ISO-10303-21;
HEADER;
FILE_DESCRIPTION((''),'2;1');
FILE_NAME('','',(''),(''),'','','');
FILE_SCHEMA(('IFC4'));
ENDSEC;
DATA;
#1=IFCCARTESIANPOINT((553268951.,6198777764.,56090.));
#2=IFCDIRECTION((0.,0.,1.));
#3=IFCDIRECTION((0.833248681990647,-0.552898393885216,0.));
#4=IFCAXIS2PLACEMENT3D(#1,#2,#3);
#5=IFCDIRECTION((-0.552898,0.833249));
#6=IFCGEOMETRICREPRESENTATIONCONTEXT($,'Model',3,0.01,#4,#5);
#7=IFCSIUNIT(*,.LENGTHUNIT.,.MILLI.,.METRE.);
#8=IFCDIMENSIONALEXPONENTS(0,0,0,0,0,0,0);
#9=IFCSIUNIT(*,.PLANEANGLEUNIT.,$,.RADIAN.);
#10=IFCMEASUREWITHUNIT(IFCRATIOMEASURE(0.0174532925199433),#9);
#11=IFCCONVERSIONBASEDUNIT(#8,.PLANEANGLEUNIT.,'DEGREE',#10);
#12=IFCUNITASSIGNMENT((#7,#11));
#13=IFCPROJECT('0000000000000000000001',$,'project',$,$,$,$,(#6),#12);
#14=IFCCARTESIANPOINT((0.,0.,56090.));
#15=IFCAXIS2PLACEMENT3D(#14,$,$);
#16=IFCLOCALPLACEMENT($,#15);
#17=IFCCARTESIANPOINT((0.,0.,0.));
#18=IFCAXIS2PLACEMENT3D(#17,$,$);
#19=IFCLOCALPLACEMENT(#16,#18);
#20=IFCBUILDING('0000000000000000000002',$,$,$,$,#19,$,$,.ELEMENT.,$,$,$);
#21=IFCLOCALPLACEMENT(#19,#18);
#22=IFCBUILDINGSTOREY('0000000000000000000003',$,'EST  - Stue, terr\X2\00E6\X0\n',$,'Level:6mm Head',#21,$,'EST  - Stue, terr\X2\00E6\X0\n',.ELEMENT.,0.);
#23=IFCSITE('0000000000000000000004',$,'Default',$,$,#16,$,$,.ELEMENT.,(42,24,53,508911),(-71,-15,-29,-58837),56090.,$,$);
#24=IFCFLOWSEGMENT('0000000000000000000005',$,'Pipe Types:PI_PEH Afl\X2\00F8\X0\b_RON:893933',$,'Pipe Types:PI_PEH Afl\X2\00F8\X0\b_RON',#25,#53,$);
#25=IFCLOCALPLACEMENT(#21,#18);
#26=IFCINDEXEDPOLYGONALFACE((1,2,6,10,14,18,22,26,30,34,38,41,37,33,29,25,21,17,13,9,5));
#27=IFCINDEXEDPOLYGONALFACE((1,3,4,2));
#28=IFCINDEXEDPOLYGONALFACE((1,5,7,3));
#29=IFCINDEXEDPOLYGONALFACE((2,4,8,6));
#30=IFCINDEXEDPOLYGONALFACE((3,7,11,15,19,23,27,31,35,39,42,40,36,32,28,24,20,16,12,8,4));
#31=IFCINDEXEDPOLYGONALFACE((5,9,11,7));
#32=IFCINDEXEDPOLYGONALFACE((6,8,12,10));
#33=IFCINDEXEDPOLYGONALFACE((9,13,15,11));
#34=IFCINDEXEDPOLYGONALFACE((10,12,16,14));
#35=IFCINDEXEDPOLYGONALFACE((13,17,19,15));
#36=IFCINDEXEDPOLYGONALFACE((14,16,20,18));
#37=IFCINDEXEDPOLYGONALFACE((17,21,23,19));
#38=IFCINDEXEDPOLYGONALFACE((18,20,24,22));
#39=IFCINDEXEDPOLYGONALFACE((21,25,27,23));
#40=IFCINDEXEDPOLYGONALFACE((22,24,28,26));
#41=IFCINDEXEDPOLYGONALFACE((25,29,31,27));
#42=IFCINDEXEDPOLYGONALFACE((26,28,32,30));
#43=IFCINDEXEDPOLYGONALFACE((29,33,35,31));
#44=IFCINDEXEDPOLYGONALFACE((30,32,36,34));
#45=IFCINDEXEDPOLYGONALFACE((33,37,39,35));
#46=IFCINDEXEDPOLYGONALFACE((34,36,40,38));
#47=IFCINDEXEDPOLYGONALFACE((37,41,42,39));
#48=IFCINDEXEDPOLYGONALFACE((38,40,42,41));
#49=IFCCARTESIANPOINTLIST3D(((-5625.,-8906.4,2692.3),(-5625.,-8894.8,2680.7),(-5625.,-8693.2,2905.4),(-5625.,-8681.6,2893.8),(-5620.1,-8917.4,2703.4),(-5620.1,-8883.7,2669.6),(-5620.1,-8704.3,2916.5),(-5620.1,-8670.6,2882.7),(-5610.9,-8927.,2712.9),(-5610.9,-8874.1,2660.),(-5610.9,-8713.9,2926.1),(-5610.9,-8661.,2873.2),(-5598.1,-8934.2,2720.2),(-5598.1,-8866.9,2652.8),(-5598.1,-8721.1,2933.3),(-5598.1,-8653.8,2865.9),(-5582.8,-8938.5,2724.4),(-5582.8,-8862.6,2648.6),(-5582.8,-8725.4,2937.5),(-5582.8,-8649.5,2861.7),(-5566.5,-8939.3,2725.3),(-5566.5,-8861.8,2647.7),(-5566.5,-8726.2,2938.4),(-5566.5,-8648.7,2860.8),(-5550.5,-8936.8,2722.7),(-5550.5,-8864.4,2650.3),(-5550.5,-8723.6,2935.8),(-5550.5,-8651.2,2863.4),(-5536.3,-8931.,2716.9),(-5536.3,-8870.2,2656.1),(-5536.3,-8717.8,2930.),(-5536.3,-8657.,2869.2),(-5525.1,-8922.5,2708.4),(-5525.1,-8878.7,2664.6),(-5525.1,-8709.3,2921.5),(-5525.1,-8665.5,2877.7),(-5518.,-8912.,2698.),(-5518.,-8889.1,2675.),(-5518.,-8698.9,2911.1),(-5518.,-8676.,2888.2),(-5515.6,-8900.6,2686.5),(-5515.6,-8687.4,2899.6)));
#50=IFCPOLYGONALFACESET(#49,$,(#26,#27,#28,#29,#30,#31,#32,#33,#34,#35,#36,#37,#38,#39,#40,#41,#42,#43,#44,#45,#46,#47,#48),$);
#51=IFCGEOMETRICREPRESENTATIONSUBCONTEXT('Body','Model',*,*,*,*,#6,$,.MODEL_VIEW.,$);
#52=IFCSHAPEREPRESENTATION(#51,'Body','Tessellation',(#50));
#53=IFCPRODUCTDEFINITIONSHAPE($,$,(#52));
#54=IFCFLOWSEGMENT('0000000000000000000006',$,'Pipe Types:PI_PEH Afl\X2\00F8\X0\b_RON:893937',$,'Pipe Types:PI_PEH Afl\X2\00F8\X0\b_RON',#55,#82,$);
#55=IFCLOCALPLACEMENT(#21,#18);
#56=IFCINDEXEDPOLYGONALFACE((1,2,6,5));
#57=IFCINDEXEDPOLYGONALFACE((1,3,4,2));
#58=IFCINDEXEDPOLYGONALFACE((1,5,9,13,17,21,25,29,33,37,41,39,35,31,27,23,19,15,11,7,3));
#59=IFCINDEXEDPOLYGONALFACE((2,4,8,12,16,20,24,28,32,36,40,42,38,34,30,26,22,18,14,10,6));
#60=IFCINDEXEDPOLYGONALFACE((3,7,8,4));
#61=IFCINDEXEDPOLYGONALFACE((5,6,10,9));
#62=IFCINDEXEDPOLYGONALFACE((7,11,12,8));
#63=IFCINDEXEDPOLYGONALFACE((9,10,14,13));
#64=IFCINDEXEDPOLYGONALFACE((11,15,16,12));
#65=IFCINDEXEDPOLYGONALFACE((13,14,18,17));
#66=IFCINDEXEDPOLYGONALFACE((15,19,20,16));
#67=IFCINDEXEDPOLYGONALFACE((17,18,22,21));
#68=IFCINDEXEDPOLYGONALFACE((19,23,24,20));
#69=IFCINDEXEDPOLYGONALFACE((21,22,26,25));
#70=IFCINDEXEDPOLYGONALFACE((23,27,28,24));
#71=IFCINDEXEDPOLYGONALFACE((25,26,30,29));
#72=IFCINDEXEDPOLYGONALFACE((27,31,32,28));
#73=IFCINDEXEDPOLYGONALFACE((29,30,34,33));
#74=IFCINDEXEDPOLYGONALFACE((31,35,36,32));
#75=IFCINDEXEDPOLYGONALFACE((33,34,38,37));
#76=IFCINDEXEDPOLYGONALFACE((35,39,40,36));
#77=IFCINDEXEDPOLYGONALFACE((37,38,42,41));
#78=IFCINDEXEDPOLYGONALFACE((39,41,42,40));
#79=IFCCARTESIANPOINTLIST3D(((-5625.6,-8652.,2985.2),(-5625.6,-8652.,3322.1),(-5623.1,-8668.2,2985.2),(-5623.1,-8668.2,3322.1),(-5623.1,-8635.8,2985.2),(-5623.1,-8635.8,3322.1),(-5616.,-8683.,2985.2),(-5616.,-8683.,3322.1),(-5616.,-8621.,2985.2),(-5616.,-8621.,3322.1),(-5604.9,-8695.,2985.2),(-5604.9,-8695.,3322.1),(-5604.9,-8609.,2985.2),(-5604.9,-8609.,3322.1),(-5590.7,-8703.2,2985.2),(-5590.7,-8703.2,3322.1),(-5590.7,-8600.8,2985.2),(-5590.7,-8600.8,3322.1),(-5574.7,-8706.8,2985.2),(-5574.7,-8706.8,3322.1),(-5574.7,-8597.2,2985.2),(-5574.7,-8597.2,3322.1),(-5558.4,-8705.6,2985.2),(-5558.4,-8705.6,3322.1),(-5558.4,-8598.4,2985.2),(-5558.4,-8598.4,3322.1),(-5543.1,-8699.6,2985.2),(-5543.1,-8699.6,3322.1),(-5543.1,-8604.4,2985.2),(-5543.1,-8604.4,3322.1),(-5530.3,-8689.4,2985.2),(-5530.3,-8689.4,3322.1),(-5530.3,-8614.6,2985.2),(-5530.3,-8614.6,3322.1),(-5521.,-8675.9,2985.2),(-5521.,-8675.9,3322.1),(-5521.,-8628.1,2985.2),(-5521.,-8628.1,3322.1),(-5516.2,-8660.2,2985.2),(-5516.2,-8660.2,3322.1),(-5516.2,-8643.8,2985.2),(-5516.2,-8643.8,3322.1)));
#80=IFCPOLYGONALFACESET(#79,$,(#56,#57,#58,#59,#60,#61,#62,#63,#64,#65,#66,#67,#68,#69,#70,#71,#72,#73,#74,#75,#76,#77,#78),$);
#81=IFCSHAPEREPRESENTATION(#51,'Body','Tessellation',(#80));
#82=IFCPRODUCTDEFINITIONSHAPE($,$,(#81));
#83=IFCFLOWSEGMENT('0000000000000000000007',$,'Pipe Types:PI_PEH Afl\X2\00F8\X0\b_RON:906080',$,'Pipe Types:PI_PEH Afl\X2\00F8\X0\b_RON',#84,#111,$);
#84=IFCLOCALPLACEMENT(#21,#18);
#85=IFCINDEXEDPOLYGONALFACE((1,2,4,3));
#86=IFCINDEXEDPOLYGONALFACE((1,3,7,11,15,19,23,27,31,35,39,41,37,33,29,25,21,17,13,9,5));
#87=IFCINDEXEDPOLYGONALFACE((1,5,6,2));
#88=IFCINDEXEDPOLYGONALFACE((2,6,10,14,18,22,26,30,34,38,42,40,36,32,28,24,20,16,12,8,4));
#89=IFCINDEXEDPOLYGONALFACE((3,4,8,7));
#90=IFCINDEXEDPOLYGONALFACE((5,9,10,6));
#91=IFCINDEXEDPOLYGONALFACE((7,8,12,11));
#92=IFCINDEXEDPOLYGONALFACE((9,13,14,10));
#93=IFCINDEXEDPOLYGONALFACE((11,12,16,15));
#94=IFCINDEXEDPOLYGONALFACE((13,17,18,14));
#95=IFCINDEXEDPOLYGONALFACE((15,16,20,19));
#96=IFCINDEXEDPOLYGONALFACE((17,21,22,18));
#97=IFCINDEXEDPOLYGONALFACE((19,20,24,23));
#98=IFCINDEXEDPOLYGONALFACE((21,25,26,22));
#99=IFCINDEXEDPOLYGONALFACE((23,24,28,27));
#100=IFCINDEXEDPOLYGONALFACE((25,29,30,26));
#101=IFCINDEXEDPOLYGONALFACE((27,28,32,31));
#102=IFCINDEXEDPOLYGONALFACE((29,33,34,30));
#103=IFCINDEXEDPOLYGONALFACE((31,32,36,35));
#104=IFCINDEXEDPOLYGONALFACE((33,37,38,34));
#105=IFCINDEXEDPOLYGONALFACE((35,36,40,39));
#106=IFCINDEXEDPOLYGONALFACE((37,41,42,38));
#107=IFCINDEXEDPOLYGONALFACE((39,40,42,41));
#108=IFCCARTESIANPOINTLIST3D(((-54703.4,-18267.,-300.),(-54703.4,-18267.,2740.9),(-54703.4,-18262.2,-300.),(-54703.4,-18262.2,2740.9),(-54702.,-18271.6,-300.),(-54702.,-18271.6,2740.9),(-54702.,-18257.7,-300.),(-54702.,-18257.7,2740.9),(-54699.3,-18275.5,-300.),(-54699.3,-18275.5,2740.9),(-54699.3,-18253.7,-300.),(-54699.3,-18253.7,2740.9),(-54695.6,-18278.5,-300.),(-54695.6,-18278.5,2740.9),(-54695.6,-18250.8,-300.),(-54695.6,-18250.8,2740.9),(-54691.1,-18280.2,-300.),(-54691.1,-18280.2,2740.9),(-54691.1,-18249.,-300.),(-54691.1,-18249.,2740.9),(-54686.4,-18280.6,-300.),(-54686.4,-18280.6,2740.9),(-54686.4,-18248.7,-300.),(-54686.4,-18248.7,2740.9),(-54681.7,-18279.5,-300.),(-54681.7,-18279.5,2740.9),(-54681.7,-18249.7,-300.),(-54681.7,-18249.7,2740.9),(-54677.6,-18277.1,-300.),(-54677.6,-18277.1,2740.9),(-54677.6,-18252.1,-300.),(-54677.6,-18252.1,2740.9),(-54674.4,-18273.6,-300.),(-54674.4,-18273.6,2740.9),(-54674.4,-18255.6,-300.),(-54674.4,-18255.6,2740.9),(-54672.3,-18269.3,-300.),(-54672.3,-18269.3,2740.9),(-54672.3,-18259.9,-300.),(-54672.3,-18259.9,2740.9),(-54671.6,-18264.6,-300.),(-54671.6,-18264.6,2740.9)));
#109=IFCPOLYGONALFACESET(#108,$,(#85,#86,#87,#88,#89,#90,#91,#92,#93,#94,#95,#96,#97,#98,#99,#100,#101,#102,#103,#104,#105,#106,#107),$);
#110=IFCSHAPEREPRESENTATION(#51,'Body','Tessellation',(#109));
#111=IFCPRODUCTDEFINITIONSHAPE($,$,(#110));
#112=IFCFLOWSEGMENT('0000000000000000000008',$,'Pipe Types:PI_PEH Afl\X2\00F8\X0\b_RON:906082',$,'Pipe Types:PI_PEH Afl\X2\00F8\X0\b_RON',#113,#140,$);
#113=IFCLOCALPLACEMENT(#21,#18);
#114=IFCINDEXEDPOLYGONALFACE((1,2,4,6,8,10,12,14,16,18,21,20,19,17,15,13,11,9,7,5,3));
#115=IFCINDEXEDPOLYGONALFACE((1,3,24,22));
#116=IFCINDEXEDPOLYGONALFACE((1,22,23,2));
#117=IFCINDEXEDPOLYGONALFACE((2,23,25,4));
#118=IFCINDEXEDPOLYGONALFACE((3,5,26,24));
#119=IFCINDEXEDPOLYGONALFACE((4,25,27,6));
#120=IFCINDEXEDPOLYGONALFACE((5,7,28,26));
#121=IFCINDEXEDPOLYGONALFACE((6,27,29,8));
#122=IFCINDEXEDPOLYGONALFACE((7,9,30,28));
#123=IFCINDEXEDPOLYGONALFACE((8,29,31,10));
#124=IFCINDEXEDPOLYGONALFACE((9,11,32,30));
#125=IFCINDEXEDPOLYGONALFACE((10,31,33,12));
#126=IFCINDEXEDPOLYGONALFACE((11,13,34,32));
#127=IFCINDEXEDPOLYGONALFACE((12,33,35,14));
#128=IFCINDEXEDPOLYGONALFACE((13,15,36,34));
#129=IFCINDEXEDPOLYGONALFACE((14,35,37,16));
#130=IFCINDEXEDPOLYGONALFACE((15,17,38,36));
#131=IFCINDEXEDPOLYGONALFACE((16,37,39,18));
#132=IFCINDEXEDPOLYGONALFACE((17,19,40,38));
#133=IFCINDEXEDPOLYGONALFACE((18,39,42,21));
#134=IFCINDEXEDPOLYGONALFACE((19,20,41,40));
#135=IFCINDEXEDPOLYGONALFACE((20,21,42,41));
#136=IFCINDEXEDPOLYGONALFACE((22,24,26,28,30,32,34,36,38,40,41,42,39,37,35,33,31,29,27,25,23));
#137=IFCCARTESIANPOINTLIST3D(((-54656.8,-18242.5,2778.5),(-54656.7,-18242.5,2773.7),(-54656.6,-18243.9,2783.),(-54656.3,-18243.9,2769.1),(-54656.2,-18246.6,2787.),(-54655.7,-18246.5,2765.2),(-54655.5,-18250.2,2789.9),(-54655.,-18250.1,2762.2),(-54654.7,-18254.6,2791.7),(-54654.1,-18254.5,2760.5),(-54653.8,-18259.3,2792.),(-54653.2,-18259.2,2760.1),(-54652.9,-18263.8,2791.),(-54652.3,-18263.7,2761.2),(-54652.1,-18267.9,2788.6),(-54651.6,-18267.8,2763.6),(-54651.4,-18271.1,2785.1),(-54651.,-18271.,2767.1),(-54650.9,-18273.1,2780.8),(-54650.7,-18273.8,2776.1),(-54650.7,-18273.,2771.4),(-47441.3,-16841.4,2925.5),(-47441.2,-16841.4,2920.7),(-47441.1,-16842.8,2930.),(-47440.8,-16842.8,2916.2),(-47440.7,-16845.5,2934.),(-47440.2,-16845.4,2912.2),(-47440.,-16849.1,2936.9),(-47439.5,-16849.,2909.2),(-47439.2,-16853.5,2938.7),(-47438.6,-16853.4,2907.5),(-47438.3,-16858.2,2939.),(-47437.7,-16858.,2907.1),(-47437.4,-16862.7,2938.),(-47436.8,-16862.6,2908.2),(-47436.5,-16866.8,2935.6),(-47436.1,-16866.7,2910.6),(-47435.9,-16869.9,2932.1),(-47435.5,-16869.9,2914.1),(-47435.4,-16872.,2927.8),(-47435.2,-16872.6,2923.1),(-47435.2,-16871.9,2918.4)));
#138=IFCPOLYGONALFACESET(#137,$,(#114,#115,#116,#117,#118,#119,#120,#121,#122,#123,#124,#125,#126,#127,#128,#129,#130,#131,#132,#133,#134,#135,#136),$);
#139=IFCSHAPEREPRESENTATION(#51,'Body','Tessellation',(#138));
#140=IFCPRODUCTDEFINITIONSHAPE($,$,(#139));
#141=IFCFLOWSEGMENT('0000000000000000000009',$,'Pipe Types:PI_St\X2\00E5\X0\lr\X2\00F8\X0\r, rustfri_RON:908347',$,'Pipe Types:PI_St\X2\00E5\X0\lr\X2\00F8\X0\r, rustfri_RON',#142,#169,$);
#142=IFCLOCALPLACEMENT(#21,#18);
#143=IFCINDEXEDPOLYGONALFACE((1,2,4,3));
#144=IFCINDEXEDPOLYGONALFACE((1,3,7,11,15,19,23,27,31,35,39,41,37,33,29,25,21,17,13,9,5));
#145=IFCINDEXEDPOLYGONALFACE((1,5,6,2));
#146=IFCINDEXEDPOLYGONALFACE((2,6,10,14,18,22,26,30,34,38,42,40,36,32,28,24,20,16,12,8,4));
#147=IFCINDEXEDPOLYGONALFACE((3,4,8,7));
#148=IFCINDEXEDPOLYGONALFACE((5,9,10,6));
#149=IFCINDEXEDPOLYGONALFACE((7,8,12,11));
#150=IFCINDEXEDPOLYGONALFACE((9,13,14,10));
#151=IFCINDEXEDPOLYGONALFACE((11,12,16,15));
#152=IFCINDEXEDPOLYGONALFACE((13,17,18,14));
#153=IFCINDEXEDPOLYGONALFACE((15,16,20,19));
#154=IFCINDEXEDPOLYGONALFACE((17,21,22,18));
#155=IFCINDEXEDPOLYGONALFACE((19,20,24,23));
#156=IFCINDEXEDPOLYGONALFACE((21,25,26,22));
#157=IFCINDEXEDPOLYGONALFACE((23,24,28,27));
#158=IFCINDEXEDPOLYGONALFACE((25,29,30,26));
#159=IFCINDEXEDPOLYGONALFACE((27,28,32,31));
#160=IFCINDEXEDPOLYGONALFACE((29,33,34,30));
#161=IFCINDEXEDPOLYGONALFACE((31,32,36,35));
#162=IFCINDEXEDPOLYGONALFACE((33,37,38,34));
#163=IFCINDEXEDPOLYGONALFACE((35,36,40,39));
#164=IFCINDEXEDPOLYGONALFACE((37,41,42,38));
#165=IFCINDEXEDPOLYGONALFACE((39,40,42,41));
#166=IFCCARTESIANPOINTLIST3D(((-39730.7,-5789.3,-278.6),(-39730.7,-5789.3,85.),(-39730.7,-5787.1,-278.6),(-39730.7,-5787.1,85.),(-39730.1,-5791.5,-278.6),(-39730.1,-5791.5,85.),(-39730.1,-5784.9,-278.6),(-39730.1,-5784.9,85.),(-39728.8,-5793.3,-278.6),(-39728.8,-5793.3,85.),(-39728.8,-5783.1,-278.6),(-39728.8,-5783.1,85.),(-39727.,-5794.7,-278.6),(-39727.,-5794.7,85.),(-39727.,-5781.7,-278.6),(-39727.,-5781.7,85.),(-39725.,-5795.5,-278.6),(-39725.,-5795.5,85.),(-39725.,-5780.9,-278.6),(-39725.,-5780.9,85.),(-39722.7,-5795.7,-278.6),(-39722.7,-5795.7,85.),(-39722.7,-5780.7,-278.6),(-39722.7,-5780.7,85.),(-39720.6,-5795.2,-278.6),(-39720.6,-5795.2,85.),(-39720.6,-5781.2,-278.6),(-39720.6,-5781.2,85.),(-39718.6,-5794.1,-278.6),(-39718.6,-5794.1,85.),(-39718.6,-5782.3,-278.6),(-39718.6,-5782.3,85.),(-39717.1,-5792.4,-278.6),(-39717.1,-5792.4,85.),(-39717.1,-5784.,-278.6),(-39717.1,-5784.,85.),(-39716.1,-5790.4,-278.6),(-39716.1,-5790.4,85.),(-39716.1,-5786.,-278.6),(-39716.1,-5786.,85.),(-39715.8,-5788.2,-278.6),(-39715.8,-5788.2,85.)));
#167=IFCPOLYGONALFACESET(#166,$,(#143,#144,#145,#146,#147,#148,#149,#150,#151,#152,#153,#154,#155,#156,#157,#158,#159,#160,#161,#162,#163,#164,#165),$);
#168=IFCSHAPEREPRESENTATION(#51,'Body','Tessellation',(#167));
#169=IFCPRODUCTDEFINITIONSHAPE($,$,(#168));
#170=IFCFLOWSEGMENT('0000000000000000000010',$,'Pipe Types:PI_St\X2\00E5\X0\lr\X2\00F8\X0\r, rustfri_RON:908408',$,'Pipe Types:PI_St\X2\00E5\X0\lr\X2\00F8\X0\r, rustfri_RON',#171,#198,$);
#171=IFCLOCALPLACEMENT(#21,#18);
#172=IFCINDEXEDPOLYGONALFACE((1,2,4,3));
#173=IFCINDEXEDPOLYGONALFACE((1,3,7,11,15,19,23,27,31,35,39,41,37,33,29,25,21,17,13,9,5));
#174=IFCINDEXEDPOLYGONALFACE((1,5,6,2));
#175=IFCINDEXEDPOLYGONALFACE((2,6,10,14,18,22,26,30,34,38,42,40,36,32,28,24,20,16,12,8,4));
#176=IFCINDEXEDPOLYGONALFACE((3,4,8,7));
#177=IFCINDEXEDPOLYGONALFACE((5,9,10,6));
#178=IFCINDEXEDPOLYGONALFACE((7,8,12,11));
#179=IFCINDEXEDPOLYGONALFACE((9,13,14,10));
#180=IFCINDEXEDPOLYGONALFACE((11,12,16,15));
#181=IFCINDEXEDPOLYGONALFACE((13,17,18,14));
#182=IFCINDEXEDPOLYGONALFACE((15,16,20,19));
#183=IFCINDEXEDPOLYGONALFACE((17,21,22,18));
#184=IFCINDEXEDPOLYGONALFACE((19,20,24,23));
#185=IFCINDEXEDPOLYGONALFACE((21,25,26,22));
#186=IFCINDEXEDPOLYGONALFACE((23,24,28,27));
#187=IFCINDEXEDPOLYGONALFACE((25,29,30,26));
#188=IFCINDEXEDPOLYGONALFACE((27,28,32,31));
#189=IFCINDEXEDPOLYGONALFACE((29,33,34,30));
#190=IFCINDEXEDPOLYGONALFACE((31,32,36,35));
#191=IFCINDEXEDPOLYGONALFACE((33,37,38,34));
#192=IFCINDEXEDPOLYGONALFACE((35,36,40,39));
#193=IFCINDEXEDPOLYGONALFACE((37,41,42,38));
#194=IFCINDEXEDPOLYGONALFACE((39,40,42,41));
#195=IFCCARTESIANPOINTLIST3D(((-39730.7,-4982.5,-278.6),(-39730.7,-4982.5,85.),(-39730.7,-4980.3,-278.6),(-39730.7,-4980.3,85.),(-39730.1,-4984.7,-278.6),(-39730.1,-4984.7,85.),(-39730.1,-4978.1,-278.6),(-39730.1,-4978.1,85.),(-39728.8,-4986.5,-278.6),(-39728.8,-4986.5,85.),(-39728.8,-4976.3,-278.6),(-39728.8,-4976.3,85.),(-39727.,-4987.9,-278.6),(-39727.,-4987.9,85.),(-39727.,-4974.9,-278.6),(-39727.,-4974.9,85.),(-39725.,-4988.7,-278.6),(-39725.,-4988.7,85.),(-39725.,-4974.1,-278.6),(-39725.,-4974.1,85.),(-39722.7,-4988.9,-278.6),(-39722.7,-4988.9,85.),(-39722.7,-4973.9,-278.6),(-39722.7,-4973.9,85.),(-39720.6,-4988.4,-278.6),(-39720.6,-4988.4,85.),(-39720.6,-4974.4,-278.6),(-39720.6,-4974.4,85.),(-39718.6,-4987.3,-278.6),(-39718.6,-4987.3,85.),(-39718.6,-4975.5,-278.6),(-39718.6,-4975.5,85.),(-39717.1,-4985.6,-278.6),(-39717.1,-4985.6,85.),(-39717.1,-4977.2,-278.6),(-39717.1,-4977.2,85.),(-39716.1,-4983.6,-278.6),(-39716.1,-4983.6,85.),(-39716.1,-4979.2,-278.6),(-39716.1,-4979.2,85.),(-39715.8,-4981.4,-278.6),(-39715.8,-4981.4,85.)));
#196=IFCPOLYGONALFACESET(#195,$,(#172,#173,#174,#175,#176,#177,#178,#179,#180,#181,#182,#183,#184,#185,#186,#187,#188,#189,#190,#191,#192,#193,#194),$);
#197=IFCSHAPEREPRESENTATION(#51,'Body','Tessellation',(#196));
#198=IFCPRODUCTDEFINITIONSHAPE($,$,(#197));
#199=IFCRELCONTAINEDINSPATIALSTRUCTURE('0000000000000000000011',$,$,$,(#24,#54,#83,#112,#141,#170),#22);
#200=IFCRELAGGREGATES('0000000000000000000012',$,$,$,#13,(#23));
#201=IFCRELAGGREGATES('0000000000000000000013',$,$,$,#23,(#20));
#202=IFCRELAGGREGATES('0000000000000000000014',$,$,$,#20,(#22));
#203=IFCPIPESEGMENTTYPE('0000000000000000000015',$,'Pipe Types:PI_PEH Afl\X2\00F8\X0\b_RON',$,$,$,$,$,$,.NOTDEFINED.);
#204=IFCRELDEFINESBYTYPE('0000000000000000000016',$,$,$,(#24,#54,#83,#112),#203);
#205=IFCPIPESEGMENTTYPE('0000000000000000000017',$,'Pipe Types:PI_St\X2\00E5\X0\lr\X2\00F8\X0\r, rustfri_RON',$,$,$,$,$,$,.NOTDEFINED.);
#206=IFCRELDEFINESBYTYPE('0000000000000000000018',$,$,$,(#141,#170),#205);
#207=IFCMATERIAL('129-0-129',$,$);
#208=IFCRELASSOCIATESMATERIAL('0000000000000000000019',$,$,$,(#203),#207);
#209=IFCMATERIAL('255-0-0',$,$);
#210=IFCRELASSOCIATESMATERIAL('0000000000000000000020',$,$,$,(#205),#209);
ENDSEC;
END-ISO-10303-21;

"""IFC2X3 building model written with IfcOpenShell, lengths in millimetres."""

from ifc_helpers import new_model, entity, si_unit, converted_unit, direction, frame, frame_2d, origin, origin_2d_with_axis, place, context, subcontext, project, spatial, circle, extrude, material, type_object, element, save


model = new_model("IFC2X3")

# Units and contexts
model_context = context("Model", 3, precision=0.01, world=frame((553268951.0, 6198777764.0, 56090.0), z_axis=(0.0, 0.0, 1.0), x_axis=(0.833248681990647, -0.552898393885216, 0.0)), true_north=direction((-0.552898, 0.833249)))
body_context = subcontext(model_context, "Body", "Model", "MODEL_VIEW")
ifc_project = project(units=[si_unit("LENGTHUNIT", "METRE", prefix="MILLI"), converted_unit("PLANEANGLEUNIT", "DEGREE", entity("IfcRatioMeasure", 0.0174532925199433), si_unit("PLANEANGLEUNIT", "RADIAN"), dimensions=[0, 0, 0, 0, 0, 0, 0])], contexts=[model_context])

# Site, building, storey
site_placement = place(None, frame((0.0, 0.0, 56090.0)))
site = spatial("IfcSite", under=ifc_project, at=site_placement, Name="Default", CompositionType="ELEMENT", RefLatitude=(42, 24, 53, 508911), RefLongitude=(-71, -15, -29, -58837), RefElevation=56090.0)
building_placement = place(site_placement, origin())
building = spatial("IfcBuilding", under=site, at=building_placement, CompositionType="ELEMENT")
storey_placement = place(building_placement, frame((0.0, 0.0, 0.0)))
storey = spatial("IfcBuildingStorey", under=building, at=storey_placement, Name="EST  - Stue, terræn", ObjectType="Level:6mm Head", LongName="EST  - Stue, terræn", CompositionType="ELEMENT", Elevation=0.0)

# Flow segments
ifc_material_1 = material(Name="129-0-129")
pipe_segment_type_1 = type_object("IfcPipeSegmentType", Name="Pipe Types:PI_PEH Afløb_RON", PredefinedType="NOTDEFINED", material=ifc_material_1)
flow_segment_1_placement = place(storey_placement, origin())
element("IfcFlowSegment", 1, at=flow_segment_1_placement, inside=storey, type_object=pipe_segment_type_1, Name="Pipe Types:PI_PEH Afløb_RON:893933", ObjectType="Pipe Types:PI_PEH Afløb_RON", context=body_context, shape_type="SweptSolid", body=[
    extrude(circle(Radius=55.0, at=frame_2d((0.0, 0.0), x_axis=(1.0, 0.0))), frame((-5570.6, -8900.6, 2686.5), z_axis=(0.0, 0.707107, 0.707107), x_axis=(1.0, 0.0, 0.0)), (0.0, 0.0, 1.0), 301.4),
])
flow_segment_2_placement = place(storey_placement, origin())
element("IfcFlowSegment", 2, at=flow_segment_2_placement, inside=storey, type_object=pipe_segment_type_1, Name="Pipe Types:PI_PEH Afløb_RON:893937", ObjectType="Pipe Types:PI_PEH Afløb_RON", context=body_context, shape_type="SweptSolid", body=[
    extrude(circle(Radius=55.0, at=origin_2d_with_axis()), frame((-5570.6, -8652.0, 2985.2), z_axis=(0.0, 0.0, 1.0), x_axis=(-1.0, 0.0, 0.0)), (0.0, 0.0, 1.0), 336.9),
])
flow_segment_3_placement = place(storey_placement, origin())
element("IfcFlowSegment", 3, at=flow_segment_3_placement, inside=storey, type_object=pipe_segment_type_1, Name="Pipe Types:PI_PEH Afløb_RON:906080", ObjectType="Pipe Types:PI_PEH Afløb_RON", context=body_context, shape_type="SweptSolid", body=[
    extrude(circle(Radius=16.0, at=frame_2d((0.0, 0.0), x_axis=(1.0, 0.0))), frame((-54687.6, -18264.6, -300.0)), (0.0, 0.0, 1.0), 3040.9),
])
flow_segment_4_placement = place(storey_placement, origin())
element("IfcFlowSegment", 4, at=flow_segment_4_placement, inside=storey, type_object=pipe_segment_type_1, Name="Pipe Types:PI_PEH Afløb_RON:906082", ObjectType="Pipe Types:PI_PEH Afløb_RON", context=body_context, shape_type="SweptSolid", body=[
    extrude(circle(Radius=16.0, at=frame_2d((0.0, 0.0), x_axis=(1.0, 0.0))), frame((-54653.7, -18258.0, 2776.1), z_axis=(0.981468, 0.190582, 0.019996), x_axis=(0.19062, -0.981664, 0.0)), (0.0, 0.0, 1.0), 7351.8),
])
ifc_material_2 = material(Name="255-0-0")
pipe_segment_type_2 = type_object("IfcPipeSegmentType", Name="Pipe Types:PI_Stålrør, rustfri_RON", PredefinedType="NOTDEFINED", material=ifc_material_2)
flow_segment_5_placement = place(storey_placement, origin())
element("IfcFlowSegment", 5, at=flow_segment_5_placement, inside=storey, type_object=pipe_segment_type_2, Name="Pipe Types:PI_Stålrør, rustfri_RON:908347", ObjectType="Pipe Types:PI_Stålrør, rustfri_RON", context=body_context, shape_type="SweptSolid", body=[
    extrude(circle(Radius=7.5, at=origin_2d_with_axis()), frame((-39723.3, -5788.2, -278.6)), (0.0, 0.0, 1.0), 363.6),
])
flow_segment_6_placement = place(storey_placement, origin())
element("IfcFlowSegment", 6, at=flow_segment_6_placement, inside=storey, type_object=pipe_segment_type_2, Name="Pipe Types:PI_Stålrør, rustfri_RON:908408", ObjectType="Pipe Types:PI_Stålrør, rustfri_RON", context=body_context, shape_type="SweptSolid", body=[
    extrude(circle(Radius=7.5, at=frame_2d((0.0, 0.0), x_axis=(1.0, 0.0))), frame((-39723.3, -4981.4, -278.6)), (0.0, 0.0, 1.0), 363.6),
])

save(model, "model.ifc")
